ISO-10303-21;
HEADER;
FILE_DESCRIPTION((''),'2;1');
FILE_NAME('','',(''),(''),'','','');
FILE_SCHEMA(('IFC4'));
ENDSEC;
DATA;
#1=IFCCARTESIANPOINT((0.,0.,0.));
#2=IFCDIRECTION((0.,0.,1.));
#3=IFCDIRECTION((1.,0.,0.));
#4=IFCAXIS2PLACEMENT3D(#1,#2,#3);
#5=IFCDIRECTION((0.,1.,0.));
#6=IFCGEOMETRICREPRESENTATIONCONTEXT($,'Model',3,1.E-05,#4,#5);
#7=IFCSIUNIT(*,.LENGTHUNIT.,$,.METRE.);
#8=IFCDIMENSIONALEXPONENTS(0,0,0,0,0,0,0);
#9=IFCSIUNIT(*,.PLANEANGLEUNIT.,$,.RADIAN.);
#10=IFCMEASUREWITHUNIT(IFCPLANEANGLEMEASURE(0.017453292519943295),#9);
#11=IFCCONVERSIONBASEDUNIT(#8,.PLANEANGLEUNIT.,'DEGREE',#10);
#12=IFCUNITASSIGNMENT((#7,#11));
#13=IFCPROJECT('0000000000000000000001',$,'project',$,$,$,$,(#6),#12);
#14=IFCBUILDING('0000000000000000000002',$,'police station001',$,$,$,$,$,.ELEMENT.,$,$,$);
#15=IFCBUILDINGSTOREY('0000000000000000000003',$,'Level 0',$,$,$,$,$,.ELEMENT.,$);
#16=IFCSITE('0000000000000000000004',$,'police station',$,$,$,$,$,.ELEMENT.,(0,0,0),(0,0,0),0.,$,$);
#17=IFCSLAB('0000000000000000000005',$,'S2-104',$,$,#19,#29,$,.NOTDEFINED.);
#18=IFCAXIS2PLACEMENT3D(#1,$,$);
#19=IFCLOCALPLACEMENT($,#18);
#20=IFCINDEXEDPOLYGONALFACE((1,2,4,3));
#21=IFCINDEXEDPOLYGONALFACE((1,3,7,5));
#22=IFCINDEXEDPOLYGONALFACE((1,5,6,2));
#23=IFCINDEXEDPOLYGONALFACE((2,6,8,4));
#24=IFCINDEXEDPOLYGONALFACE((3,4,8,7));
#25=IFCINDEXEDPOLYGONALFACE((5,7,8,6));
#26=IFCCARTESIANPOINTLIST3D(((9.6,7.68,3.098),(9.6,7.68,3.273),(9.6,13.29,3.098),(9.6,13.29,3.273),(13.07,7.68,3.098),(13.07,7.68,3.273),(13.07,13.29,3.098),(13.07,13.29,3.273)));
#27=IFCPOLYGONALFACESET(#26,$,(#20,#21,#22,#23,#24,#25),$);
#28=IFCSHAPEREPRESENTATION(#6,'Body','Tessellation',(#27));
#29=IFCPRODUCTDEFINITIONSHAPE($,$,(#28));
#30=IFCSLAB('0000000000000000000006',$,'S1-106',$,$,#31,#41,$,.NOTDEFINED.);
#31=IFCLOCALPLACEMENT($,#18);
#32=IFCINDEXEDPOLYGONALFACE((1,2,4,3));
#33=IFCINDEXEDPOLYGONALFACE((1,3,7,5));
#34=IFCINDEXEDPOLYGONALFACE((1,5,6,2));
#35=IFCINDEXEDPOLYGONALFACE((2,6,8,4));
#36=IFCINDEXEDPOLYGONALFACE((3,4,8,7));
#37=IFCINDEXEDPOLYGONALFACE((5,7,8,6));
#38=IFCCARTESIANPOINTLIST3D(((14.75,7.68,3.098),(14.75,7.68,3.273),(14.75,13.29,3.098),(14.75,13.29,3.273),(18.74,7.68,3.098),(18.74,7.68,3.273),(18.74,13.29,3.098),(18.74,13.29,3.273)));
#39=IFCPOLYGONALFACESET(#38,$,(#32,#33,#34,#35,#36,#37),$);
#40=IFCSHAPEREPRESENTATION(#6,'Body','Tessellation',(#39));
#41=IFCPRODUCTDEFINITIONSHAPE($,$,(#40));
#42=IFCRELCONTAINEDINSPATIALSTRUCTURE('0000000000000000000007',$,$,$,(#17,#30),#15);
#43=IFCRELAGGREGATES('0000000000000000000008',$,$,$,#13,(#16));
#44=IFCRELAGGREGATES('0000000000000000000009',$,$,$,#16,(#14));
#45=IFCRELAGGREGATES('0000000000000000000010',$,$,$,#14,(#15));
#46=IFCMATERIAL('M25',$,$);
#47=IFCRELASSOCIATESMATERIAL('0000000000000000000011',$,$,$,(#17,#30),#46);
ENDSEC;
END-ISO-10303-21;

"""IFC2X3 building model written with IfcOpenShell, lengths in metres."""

from ifc_helpers import new_model, entity, si_unit, converted_unit, direction, frame, frame_2d, origin_with_axes, place, context, project, spatial, rectangle, extrude, material, element, save


model = new_model("IFC2X3")

# Units and contexts
model_context = context("Model", 3, precision=1e-05, world=origin_with_axes(), true_north=direction((0.0, 1.0, 0.0)))
ifc_project = project(units=[si_unit("LENGTHUNIT", "METRE"), converted_unit("PLANEANGLEUNIT", "DEGREE", entity("IfcPlaneAngleMeasure", 0.017453292519943295), si_unit("PLANEANGLEUNIT", "RADIAN"), dimensions=[0, 0, 0, 0, 0, 0, 0])], contexts=[model_context])

# Site, building, storey
site = spatial("IfcSite", under=ifc_project, Name="police station", CompositionType="ELEMENT", RefLatitude=(0, 0, 0), RefLongitude=(0, 0, 0), RefElevation=0.0)
building = spatial("IfcBuilding", under=site, Name="police station001", CompositionType="ELEMENT")
storey = spatial("IfcBuildingStorey", under=building, Name="Level 0", CompositionType="ELEMENT")

# Shared definitions
ifc_material = material(Name="M25")
placement = place(None, origin_with_axes())

# Slabs
element("IfcSlab", 1, at=placement, inside=storey, material=ifc_material, Name="S2-104", PredefinedType="NOTDEFINED", context=model_context, shape_type="SweptSolid", body=[
    extrude(rectangle(XDim=3.47, YDim=5.61, at=frame_2d((0.0, 0.0), x_axis=(1.0, 0.0, 0.0))), frame((11.335, 10.485, 3.098), z_axis=(0.0, 0.0, 1.0), x_axis=(1.0, 0.0, 0.0)), (0.0, 0.0, 1.0), 0.175),
])
element("IfcSlab", 2, at=placement, inside=storey, material=ifc_material, Name="S1-106", PredefinedType="NOTDEFINED", context=model_context, shape_type="SweptSolid", body=[
    extrude(rectangle(XDim=3.99, YDim=5.61, at=frame_2d((0.0, 0.0), x_axis=(1.0, 0.0, 0.0))), frame((16.745, 10.485, 3.098), z_axis=(0.0, 0.0, 1.0), x_axis=(1.0, 0.0, 0.0)), (0.0, 0.0, 1.0), 0.175),
])

save(model, "model.ifc")
